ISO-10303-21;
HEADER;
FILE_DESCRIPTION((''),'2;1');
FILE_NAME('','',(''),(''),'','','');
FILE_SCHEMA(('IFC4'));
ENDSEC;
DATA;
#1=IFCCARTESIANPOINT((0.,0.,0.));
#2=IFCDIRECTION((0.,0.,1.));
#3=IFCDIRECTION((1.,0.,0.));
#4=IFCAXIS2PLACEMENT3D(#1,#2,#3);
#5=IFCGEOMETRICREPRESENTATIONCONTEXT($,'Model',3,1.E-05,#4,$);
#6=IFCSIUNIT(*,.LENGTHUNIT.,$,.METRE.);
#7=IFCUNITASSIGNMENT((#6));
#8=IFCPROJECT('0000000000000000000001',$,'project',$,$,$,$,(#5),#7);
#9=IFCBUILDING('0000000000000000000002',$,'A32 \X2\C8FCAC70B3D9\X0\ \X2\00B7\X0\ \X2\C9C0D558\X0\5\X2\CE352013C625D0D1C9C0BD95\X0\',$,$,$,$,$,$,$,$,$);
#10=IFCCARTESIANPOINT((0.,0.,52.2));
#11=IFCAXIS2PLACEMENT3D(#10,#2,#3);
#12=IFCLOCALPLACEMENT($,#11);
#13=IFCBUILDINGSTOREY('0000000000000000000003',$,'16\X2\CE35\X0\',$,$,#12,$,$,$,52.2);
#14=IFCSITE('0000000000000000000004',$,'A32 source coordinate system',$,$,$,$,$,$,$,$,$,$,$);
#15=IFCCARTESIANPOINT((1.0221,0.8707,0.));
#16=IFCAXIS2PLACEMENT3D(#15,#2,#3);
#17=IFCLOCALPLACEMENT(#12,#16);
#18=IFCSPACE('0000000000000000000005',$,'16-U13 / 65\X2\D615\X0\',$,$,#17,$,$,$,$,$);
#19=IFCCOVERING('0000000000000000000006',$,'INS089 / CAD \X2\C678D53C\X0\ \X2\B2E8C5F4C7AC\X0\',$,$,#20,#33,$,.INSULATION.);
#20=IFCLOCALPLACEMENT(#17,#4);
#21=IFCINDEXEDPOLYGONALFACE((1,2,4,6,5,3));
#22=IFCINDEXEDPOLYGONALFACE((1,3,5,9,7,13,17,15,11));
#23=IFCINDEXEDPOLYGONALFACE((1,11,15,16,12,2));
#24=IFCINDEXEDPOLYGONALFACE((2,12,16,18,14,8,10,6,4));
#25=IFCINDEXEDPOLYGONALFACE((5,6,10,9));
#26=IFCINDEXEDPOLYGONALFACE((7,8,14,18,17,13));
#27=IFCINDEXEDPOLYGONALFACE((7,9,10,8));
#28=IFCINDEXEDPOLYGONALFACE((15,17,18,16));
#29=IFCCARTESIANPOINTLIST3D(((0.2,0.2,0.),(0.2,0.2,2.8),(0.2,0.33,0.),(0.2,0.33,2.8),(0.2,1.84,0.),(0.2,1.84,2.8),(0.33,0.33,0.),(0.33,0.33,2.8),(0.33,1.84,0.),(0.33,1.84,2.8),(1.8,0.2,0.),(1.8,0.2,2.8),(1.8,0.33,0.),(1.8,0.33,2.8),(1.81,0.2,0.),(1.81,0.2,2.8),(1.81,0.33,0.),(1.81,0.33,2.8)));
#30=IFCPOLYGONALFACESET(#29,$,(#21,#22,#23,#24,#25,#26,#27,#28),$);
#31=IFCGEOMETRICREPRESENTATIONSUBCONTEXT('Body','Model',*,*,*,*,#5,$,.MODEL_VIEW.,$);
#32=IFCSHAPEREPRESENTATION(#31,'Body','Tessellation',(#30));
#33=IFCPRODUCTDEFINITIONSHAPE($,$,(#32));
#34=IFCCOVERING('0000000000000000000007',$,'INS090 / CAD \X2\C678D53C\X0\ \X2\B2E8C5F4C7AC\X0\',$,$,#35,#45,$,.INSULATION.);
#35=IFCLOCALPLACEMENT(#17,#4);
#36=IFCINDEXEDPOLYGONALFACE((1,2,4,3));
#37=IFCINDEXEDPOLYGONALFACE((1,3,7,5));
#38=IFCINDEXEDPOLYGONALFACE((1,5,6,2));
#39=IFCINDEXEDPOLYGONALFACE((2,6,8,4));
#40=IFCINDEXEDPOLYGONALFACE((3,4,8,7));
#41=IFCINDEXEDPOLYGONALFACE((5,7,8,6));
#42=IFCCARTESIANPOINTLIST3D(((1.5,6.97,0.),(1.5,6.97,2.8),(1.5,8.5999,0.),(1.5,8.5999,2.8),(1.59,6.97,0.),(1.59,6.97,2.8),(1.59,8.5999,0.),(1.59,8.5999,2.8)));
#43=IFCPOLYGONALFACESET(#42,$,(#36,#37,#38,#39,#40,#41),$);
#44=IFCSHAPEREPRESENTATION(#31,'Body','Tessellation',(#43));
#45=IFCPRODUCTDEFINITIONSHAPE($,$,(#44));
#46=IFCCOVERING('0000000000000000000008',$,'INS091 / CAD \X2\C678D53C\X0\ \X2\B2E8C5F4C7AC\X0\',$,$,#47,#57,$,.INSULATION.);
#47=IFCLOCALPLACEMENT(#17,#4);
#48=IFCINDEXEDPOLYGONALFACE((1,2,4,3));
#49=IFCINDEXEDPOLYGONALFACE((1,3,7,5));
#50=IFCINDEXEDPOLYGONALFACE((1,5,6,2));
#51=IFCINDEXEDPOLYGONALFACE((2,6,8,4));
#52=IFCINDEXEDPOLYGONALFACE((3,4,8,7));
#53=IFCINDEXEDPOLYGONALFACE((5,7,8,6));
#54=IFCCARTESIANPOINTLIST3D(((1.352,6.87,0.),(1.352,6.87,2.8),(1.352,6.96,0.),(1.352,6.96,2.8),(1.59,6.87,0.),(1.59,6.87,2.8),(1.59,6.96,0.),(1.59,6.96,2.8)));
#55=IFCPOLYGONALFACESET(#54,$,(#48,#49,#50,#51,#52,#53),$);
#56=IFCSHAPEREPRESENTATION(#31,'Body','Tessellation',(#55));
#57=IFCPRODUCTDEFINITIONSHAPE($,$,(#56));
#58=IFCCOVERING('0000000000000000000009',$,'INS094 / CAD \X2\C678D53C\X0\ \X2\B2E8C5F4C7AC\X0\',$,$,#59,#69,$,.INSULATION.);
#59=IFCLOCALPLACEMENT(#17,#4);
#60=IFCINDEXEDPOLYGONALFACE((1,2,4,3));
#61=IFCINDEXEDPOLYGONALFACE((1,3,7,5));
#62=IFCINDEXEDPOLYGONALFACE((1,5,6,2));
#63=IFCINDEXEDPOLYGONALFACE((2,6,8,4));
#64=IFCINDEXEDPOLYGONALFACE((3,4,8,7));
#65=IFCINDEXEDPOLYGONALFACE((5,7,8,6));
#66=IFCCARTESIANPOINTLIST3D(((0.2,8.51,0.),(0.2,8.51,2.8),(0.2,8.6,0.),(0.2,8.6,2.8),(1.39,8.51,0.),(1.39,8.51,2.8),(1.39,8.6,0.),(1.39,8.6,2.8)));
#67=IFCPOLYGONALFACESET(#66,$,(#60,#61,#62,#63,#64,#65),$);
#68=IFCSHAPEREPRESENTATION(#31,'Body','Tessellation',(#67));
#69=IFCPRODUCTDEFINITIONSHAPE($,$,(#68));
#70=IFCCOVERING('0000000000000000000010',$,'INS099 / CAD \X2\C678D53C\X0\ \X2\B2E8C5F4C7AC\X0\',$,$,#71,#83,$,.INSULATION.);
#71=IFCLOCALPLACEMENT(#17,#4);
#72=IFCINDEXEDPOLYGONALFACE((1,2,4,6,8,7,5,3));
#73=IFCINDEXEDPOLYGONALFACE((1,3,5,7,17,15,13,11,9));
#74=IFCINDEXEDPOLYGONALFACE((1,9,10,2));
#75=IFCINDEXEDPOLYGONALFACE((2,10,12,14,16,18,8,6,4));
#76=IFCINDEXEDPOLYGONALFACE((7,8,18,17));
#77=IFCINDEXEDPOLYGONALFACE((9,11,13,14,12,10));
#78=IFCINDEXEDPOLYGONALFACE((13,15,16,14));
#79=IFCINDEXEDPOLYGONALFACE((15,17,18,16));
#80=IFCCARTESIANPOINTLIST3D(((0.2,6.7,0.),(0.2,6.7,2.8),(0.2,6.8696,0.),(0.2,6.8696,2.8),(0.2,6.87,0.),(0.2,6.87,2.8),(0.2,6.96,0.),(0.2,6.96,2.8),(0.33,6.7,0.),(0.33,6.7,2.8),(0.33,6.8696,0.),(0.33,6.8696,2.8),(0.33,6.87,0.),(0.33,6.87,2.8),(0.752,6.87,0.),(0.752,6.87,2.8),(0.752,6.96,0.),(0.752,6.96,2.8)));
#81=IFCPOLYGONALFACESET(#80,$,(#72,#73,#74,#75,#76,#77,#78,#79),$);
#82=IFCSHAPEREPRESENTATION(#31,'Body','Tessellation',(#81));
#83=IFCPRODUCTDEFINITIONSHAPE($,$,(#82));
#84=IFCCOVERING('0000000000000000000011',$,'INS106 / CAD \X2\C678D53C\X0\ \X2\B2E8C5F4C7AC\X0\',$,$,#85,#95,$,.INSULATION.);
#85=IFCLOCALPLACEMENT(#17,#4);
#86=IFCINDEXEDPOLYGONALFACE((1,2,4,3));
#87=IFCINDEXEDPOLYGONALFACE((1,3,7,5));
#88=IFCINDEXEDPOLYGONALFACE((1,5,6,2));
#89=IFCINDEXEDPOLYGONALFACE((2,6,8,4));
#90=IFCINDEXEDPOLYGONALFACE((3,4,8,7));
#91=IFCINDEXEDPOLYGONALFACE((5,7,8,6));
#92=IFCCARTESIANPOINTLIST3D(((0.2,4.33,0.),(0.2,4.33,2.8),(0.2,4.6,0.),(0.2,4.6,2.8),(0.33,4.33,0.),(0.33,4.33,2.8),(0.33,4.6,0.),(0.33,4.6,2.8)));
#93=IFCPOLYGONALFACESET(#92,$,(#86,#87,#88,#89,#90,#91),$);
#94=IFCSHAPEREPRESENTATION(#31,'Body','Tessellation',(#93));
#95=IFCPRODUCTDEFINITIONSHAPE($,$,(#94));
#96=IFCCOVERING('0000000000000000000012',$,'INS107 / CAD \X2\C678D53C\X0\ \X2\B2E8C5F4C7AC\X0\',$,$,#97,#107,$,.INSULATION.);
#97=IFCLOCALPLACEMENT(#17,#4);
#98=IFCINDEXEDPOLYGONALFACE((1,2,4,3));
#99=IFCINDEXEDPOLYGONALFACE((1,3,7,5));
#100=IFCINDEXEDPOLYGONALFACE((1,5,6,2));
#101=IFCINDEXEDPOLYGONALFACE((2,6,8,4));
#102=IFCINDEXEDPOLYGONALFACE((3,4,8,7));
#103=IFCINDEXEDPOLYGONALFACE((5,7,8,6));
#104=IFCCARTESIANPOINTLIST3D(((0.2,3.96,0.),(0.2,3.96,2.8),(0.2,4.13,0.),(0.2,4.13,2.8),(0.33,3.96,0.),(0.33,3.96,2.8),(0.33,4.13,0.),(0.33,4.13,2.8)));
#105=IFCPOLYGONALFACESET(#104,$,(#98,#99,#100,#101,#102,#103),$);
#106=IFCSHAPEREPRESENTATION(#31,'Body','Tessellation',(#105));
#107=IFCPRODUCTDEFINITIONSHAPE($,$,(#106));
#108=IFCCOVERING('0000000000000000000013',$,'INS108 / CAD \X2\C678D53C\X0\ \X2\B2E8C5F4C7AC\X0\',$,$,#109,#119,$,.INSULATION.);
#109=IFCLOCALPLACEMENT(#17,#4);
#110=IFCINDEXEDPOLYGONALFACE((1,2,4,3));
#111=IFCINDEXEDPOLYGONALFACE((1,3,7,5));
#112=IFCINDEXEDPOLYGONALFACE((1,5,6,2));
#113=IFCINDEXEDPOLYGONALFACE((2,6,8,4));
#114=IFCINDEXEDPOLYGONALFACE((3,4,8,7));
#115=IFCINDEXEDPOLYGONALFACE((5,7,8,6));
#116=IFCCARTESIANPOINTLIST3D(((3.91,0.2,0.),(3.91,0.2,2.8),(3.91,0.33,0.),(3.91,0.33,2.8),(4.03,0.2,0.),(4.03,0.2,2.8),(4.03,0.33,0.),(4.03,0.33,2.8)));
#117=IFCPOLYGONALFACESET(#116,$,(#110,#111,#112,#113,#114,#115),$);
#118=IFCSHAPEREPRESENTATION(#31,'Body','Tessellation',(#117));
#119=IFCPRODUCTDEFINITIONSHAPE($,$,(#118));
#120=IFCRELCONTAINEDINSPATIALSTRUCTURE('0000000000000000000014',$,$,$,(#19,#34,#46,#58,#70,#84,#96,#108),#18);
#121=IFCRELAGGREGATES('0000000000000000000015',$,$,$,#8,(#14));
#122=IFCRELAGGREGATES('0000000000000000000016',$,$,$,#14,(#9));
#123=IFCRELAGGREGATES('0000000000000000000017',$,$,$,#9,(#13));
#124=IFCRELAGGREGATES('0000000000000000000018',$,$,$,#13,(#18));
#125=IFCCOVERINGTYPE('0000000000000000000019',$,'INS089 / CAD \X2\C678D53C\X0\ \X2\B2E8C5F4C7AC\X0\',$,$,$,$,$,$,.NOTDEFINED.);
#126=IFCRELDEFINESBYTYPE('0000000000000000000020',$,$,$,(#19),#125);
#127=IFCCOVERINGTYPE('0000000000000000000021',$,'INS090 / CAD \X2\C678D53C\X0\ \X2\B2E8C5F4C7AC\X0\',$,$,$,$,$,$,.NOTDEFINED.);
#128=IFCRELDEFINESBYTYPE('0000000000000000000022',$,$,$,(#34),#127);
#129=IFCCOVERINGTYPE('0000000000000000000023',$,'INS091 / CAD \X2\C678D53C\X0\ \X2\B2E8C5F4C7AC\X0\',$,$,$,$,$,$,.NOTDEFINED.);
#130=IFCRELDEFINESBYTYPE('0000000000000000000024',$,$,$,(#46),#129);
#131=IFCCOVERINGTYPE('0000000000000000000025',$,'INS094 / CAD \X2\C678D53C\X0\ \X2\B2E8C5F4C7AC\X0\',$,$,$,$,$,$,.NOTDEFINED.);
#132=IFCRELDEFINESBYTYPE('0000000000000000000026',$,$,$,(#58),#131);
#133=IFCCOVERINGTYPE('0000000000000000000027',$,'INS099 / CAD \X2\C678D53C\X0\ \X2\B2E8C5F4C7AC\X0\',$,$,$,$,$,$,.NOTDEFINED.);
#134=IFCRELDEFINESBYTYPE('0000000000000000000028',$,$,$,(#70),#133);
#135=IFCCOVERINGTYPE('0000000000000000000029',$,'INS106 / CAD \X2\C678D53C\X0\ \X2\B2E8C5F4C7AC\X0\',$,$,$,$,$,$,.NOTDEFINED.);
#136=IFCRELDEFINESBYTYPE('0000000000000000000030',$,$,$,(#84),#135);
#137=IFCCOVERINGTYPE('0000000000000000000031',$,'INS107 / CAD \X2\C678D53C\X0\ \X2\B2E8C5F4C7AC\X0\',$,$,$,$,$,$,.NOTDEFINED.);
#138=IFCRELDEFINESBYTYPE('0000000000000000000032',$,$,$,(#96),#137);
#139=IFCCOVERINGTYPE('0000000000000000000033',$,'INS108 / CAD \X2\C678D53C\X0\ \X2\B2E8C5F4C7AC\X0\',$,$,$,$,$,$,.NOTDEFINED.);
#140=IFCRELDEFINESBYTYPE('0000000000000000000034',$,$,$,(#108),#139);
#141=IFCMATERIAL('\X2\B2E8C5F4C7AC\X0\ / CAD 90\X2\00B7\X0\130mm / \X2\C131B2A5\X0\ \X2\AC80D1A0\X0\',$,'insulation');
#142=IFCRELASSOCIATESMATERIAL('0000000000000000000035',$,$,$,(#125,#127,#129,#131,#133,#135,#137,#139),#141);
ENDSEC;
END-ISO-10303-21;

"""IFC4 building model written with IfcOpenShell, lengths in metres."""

from ifc_helpers import new_model, si_unit, frame, origin, origin_with_axes, place, context, subcontext, project, spatial, polyline, outline, extrude, source, transform, mapped, material, type_object, type_shapes, element, save


model = new_model("IFC4")

# Units and contexts
model_context = context("Model", 3, precision=1e-05, world=origin_with_axes())
body_context = subcontext(model_context, "Body", "Model", "MODEL_VIEW")
ifc_project = project(units=[si_unit("LENGTHUNIT", "METRE")], contexts=[model_context])

# Site, building, storey
site = spatial("IfcSite", under=ifc_project, Name="A32 source coordinate system")
building = spatial("IfcBuilding", under=site, Name="A32 주거동 · 지하5층–옥탑지붕")
storey_placement = place(None, frame((0.0, 0.0, 52.2), z_axis=(0.0, 0.0, 1.0), x_axis=(1.0, 0.0, 0.0)))
storey = spatial("IfcBuildingStorey", under=building, at=storey_placement, Name="16층", Elevation=52.2)

# Shared definitions
space_placement = place(storey_placement, frame((1.0221, 0.8707, 0.0), z_axis=(0.0, 0.0, 1.0), x_axis=(1.0, 0.0, 0.0)))
space = spatial("IfcSpace", under=storey, at=space_placement, Name="16-U13 / 65형")

# Coverings
ifc_material = material(Name="단열재 / CAD 90·130mm / 성능 검토", Category="insulation")
covering_type_1 = type_object("IfcCoveringType", Name="INS089 / CAD 외피 단열재", PredefinedType="NOTDEFINED", material=ifc_material)
shared_shape_1 = source(origin(), body_context, "Body", "SweptSolid", [
    extrude(outline(polyline([(0.2, 0.33), (0.2, 1.84), (0.33, 1.84), (0.33, 0.33), (1.8, 0.33), (1.81, 0.33), (1.81, 0.2), (1.8, 0.2), (0.2, 0.2), (0.2, 0.33)])), origin(), (0.0, 0.0, 1.0), 2.8),
])
type_shapes(covering_type_1, [shared_shape_1])
covering_1_placement = place(space_placement, origin_with_axes())
element("IfcCovering", 1, at=covering_1_placement, inside=space, type_object=covering_type_1, Name="INS089 / CAD 외피 단열재", PredefinedType="INSULATION", context=body_context, shape_type="MappedRepresentation", body=[
    mapped(shared_shape_1, transform((0.0, 0.0, 0.0), scale=1.0)),
])
covering_type_2 = type_object("IfcCoveringType", Name="INS090 / CAD 외피 단열재", PredefinedType="NOTDEFINED", material=ifc_material)
shared_shape_2 = source(origin(), body_context, "Body", "SweptSolid", [
    extrude(outline(polyline([(1.59, 6.97), (1.5, 6.97), (1.5, 8.5999), (1.59, 8.5999), (1.59, 6.97)])), origin(), (0.0, 0.0, 1.0), 2.8),
])
type_shapes(covering_type_2, [shared_shape_2])
covering_2_placement = place(space_placement, origin_with_axes())
element("IfcCovering", 2, at=covering_2_placement, inside=space, type_object=covering_type_2, Name="INS090 / CAD 외피 단열재", PredefinedType="INSULATION", context=body_context, shape_type="MappedRepresentation", body=[
    mapped(shared_shape_2, transform((0.0, 0.0, 0.0), scale=1.0)),
])
covering_type_3 = type_object("IfcCoveringType", Name="INS091 / CAD 외피 단열재", PredefinedType="NOTDEFINED", material=ifc_material)
shared_shape_3 = source(origin(), body_context, "Body", "SweptSolid", [
    extrude(outline(polyline([(1.59, 6.96), (1.59, 6.87), (1.352, 6.87), (1.352, 6.96), (1.59, 6.96)])), origin(), (0.0, 0.0, 1.0), 2.8),
])
type_shapes(covering_type_3, [shared_shape_3])
covering_3_placement = place(space_placement, origin_with_axes())
element("IfcCovering", 3, at=covering_3_placement, inside=space, type_object=covering_type_3, Name="INS091 / CAD 외피 단열재", PredefinedType="INSULATION", context=body_context, shape_type="MappedRepresentation", body=[
    mapped(shared_shape_3, transform((0.0, 0.0, 0.0), scale=1.0)),
])
covering_type_4 = type_object("IfcCoveringType", Name="INS094 / CAD 외피 단열재", PredefinedType="NOTDEFINED", material=ifc_material)
shared_shape_4 = source(origin(), body_context, "Body", "SweptSolid", [
    extrude(outline(polyline([(1.39, 8.51), (0.2, 8.51), (0.2, 8.6), (1.39, 8.6), (1.39, 8.51)])), origin(), (0.0, 0.0, 1.0), 2.8),
])
type_shapes(covering_type_4, [shared_shape_4])
covering_4_placement = place(space_placement, origin_with_axes())
element("IfcCovering", 4, at=covering_4_placement, inside=space, type_object=covering_type_4, Name="INS094 / CAD 외피 단열재", PredefinedType="INSULATION", context=body_context, shape_type="MappedRepresentation", body=[
    mapped(shared_shape_4, transform((0.0, 0.0, 0.0), scale=1.0)),
])
covering_type_5 = type_object("IfcCoveringType", Name="INS099 / CAD 외피 단열재", PredefinedType="NOTDEFINED", material=ifc_material)
shared_shape_5 = source(origin(), body_context, "Body", "SweptSolid", [
    extrude(outline(polyline([(0.2, 6.8696), (0.2, 6.87), (0.2, 6.96), (0.752, 6.96), (0.752, 6.87), (0.33, 6.87), (0.33, 6.8696), (0.33, 6.7), (0.2, 6.7), (0.2, 6.8696)])), origin(), (0.0, 0.0, 1.0), 2.8),
])
type_shapes(covering_type_5, [shared_shape_5])
covering_5_placement = place(space_placement, origin_with_axes())
element("IfcCovering", 5, at=covering_5_placement, inside=space, type_object=covering_type_5, Name="INS099 / CAD 외피 단열재", PredefinedType="INSULATION", context=body_context, shape_type="MappedRepresentation", body=[
    mapped(shared_shape_5, transform((0.0, 0.0, 0.0), scale=1.0)),
])
covering_type_6 = type_object("IfcCoveringType", Name="INS106 / CAD 외피 단열재", PredefinedType="NOTDEFINED", material=ifc_material)
shared_shape_6 = source(origin(), body_context, "Body", "SweptSolid", [
    extrude(outline(polyline([(0.33, 4.6), (0.33, 4.33), (0.2, 4.33), (0.2, 4.6), (0.33, 4.6)])), origin(), (0.0, 0.0, 1.0), 2.8),
])
type_shapes(covering_type_6, [shared_shape_6])
covering_6_placement = place(space_placement, origin_with_axes())
element("IfcCovering", 6, at=covering_6_placement, inside=space, type_object=covering_type_6, Name="INS106 / CAD 외피 단열재", PredefinedType="INSULATION", context=body_context, shape_type="MappedRepresentation", body=[
    mapped(shared_shape_6, transform((0.0, 0.0, 0.0), scale=1.0)),
])
covering_type_7 = type_object("IfcCoveringType", Name="INS107 / CAD 외피 단열재", PredefinedType="NOTDEFINED", material=ifc_material)
shared_shape_7 = source(origin(), body_context, "Body", "SweptSolid", [
    extrude(outline(polyline([(0.33, 3.96), (0.2, 3.96), (0.2, 4.13), (0.33, 4.13), (0.33, 3.96)])), origin(), (0.0, 0.0, 1.0), 2.8),
])
type_shapes(covering_type_7, [shared_shape_7])
covering_7_placement = place(space_placement, origin_with_axes())
element("IfcCovering", 7, at=covering_7_placement, inside=space, type_object=covering_type_7, Name="INS107 / CAD 외피 단열재", PredefinedType="INSULATION", context=body_context, shape_type="MappedRepresentation", body=[
    mapped(shared_shape_7, transform((0.0, 0.0, 0.0), scale=1.0)),
])
covering_type_8 = type_object("IfcCoveringType", Name="INS108 / CAD 외피 단열재", PredefinedType="NOTDEFINED", material=ifc_material)
shared_shape_8 = source(origin(), body_context, "Body", "SweptSolid", [
    extrude(outline(polyline([(4.03, 0.2), (3.91, 0.2), (3.91, 0.33), (4.03, 0.33), (4.03, 0.2)])), origin(), (0.0, 0.0, 1.0), 2.8),
])
type_shapes(covering_type_8, [shared_shape_8])
covering_8_placement = place(space_placement, origin_with_axes())
element("IfcCovering", 8, at=covering_8_placement, inside=space, type_object=covering_type_8, Name="INS108 / CAD 외피 단열재", PredefinedType="INSULATION", context=body_context, shape_type="MappedRepresentation", body=[
    mapped(shared_shape_8, transform((0.0, 0.0, 0.0), scale=1.0)),
])

save(model, "model.ifc")
